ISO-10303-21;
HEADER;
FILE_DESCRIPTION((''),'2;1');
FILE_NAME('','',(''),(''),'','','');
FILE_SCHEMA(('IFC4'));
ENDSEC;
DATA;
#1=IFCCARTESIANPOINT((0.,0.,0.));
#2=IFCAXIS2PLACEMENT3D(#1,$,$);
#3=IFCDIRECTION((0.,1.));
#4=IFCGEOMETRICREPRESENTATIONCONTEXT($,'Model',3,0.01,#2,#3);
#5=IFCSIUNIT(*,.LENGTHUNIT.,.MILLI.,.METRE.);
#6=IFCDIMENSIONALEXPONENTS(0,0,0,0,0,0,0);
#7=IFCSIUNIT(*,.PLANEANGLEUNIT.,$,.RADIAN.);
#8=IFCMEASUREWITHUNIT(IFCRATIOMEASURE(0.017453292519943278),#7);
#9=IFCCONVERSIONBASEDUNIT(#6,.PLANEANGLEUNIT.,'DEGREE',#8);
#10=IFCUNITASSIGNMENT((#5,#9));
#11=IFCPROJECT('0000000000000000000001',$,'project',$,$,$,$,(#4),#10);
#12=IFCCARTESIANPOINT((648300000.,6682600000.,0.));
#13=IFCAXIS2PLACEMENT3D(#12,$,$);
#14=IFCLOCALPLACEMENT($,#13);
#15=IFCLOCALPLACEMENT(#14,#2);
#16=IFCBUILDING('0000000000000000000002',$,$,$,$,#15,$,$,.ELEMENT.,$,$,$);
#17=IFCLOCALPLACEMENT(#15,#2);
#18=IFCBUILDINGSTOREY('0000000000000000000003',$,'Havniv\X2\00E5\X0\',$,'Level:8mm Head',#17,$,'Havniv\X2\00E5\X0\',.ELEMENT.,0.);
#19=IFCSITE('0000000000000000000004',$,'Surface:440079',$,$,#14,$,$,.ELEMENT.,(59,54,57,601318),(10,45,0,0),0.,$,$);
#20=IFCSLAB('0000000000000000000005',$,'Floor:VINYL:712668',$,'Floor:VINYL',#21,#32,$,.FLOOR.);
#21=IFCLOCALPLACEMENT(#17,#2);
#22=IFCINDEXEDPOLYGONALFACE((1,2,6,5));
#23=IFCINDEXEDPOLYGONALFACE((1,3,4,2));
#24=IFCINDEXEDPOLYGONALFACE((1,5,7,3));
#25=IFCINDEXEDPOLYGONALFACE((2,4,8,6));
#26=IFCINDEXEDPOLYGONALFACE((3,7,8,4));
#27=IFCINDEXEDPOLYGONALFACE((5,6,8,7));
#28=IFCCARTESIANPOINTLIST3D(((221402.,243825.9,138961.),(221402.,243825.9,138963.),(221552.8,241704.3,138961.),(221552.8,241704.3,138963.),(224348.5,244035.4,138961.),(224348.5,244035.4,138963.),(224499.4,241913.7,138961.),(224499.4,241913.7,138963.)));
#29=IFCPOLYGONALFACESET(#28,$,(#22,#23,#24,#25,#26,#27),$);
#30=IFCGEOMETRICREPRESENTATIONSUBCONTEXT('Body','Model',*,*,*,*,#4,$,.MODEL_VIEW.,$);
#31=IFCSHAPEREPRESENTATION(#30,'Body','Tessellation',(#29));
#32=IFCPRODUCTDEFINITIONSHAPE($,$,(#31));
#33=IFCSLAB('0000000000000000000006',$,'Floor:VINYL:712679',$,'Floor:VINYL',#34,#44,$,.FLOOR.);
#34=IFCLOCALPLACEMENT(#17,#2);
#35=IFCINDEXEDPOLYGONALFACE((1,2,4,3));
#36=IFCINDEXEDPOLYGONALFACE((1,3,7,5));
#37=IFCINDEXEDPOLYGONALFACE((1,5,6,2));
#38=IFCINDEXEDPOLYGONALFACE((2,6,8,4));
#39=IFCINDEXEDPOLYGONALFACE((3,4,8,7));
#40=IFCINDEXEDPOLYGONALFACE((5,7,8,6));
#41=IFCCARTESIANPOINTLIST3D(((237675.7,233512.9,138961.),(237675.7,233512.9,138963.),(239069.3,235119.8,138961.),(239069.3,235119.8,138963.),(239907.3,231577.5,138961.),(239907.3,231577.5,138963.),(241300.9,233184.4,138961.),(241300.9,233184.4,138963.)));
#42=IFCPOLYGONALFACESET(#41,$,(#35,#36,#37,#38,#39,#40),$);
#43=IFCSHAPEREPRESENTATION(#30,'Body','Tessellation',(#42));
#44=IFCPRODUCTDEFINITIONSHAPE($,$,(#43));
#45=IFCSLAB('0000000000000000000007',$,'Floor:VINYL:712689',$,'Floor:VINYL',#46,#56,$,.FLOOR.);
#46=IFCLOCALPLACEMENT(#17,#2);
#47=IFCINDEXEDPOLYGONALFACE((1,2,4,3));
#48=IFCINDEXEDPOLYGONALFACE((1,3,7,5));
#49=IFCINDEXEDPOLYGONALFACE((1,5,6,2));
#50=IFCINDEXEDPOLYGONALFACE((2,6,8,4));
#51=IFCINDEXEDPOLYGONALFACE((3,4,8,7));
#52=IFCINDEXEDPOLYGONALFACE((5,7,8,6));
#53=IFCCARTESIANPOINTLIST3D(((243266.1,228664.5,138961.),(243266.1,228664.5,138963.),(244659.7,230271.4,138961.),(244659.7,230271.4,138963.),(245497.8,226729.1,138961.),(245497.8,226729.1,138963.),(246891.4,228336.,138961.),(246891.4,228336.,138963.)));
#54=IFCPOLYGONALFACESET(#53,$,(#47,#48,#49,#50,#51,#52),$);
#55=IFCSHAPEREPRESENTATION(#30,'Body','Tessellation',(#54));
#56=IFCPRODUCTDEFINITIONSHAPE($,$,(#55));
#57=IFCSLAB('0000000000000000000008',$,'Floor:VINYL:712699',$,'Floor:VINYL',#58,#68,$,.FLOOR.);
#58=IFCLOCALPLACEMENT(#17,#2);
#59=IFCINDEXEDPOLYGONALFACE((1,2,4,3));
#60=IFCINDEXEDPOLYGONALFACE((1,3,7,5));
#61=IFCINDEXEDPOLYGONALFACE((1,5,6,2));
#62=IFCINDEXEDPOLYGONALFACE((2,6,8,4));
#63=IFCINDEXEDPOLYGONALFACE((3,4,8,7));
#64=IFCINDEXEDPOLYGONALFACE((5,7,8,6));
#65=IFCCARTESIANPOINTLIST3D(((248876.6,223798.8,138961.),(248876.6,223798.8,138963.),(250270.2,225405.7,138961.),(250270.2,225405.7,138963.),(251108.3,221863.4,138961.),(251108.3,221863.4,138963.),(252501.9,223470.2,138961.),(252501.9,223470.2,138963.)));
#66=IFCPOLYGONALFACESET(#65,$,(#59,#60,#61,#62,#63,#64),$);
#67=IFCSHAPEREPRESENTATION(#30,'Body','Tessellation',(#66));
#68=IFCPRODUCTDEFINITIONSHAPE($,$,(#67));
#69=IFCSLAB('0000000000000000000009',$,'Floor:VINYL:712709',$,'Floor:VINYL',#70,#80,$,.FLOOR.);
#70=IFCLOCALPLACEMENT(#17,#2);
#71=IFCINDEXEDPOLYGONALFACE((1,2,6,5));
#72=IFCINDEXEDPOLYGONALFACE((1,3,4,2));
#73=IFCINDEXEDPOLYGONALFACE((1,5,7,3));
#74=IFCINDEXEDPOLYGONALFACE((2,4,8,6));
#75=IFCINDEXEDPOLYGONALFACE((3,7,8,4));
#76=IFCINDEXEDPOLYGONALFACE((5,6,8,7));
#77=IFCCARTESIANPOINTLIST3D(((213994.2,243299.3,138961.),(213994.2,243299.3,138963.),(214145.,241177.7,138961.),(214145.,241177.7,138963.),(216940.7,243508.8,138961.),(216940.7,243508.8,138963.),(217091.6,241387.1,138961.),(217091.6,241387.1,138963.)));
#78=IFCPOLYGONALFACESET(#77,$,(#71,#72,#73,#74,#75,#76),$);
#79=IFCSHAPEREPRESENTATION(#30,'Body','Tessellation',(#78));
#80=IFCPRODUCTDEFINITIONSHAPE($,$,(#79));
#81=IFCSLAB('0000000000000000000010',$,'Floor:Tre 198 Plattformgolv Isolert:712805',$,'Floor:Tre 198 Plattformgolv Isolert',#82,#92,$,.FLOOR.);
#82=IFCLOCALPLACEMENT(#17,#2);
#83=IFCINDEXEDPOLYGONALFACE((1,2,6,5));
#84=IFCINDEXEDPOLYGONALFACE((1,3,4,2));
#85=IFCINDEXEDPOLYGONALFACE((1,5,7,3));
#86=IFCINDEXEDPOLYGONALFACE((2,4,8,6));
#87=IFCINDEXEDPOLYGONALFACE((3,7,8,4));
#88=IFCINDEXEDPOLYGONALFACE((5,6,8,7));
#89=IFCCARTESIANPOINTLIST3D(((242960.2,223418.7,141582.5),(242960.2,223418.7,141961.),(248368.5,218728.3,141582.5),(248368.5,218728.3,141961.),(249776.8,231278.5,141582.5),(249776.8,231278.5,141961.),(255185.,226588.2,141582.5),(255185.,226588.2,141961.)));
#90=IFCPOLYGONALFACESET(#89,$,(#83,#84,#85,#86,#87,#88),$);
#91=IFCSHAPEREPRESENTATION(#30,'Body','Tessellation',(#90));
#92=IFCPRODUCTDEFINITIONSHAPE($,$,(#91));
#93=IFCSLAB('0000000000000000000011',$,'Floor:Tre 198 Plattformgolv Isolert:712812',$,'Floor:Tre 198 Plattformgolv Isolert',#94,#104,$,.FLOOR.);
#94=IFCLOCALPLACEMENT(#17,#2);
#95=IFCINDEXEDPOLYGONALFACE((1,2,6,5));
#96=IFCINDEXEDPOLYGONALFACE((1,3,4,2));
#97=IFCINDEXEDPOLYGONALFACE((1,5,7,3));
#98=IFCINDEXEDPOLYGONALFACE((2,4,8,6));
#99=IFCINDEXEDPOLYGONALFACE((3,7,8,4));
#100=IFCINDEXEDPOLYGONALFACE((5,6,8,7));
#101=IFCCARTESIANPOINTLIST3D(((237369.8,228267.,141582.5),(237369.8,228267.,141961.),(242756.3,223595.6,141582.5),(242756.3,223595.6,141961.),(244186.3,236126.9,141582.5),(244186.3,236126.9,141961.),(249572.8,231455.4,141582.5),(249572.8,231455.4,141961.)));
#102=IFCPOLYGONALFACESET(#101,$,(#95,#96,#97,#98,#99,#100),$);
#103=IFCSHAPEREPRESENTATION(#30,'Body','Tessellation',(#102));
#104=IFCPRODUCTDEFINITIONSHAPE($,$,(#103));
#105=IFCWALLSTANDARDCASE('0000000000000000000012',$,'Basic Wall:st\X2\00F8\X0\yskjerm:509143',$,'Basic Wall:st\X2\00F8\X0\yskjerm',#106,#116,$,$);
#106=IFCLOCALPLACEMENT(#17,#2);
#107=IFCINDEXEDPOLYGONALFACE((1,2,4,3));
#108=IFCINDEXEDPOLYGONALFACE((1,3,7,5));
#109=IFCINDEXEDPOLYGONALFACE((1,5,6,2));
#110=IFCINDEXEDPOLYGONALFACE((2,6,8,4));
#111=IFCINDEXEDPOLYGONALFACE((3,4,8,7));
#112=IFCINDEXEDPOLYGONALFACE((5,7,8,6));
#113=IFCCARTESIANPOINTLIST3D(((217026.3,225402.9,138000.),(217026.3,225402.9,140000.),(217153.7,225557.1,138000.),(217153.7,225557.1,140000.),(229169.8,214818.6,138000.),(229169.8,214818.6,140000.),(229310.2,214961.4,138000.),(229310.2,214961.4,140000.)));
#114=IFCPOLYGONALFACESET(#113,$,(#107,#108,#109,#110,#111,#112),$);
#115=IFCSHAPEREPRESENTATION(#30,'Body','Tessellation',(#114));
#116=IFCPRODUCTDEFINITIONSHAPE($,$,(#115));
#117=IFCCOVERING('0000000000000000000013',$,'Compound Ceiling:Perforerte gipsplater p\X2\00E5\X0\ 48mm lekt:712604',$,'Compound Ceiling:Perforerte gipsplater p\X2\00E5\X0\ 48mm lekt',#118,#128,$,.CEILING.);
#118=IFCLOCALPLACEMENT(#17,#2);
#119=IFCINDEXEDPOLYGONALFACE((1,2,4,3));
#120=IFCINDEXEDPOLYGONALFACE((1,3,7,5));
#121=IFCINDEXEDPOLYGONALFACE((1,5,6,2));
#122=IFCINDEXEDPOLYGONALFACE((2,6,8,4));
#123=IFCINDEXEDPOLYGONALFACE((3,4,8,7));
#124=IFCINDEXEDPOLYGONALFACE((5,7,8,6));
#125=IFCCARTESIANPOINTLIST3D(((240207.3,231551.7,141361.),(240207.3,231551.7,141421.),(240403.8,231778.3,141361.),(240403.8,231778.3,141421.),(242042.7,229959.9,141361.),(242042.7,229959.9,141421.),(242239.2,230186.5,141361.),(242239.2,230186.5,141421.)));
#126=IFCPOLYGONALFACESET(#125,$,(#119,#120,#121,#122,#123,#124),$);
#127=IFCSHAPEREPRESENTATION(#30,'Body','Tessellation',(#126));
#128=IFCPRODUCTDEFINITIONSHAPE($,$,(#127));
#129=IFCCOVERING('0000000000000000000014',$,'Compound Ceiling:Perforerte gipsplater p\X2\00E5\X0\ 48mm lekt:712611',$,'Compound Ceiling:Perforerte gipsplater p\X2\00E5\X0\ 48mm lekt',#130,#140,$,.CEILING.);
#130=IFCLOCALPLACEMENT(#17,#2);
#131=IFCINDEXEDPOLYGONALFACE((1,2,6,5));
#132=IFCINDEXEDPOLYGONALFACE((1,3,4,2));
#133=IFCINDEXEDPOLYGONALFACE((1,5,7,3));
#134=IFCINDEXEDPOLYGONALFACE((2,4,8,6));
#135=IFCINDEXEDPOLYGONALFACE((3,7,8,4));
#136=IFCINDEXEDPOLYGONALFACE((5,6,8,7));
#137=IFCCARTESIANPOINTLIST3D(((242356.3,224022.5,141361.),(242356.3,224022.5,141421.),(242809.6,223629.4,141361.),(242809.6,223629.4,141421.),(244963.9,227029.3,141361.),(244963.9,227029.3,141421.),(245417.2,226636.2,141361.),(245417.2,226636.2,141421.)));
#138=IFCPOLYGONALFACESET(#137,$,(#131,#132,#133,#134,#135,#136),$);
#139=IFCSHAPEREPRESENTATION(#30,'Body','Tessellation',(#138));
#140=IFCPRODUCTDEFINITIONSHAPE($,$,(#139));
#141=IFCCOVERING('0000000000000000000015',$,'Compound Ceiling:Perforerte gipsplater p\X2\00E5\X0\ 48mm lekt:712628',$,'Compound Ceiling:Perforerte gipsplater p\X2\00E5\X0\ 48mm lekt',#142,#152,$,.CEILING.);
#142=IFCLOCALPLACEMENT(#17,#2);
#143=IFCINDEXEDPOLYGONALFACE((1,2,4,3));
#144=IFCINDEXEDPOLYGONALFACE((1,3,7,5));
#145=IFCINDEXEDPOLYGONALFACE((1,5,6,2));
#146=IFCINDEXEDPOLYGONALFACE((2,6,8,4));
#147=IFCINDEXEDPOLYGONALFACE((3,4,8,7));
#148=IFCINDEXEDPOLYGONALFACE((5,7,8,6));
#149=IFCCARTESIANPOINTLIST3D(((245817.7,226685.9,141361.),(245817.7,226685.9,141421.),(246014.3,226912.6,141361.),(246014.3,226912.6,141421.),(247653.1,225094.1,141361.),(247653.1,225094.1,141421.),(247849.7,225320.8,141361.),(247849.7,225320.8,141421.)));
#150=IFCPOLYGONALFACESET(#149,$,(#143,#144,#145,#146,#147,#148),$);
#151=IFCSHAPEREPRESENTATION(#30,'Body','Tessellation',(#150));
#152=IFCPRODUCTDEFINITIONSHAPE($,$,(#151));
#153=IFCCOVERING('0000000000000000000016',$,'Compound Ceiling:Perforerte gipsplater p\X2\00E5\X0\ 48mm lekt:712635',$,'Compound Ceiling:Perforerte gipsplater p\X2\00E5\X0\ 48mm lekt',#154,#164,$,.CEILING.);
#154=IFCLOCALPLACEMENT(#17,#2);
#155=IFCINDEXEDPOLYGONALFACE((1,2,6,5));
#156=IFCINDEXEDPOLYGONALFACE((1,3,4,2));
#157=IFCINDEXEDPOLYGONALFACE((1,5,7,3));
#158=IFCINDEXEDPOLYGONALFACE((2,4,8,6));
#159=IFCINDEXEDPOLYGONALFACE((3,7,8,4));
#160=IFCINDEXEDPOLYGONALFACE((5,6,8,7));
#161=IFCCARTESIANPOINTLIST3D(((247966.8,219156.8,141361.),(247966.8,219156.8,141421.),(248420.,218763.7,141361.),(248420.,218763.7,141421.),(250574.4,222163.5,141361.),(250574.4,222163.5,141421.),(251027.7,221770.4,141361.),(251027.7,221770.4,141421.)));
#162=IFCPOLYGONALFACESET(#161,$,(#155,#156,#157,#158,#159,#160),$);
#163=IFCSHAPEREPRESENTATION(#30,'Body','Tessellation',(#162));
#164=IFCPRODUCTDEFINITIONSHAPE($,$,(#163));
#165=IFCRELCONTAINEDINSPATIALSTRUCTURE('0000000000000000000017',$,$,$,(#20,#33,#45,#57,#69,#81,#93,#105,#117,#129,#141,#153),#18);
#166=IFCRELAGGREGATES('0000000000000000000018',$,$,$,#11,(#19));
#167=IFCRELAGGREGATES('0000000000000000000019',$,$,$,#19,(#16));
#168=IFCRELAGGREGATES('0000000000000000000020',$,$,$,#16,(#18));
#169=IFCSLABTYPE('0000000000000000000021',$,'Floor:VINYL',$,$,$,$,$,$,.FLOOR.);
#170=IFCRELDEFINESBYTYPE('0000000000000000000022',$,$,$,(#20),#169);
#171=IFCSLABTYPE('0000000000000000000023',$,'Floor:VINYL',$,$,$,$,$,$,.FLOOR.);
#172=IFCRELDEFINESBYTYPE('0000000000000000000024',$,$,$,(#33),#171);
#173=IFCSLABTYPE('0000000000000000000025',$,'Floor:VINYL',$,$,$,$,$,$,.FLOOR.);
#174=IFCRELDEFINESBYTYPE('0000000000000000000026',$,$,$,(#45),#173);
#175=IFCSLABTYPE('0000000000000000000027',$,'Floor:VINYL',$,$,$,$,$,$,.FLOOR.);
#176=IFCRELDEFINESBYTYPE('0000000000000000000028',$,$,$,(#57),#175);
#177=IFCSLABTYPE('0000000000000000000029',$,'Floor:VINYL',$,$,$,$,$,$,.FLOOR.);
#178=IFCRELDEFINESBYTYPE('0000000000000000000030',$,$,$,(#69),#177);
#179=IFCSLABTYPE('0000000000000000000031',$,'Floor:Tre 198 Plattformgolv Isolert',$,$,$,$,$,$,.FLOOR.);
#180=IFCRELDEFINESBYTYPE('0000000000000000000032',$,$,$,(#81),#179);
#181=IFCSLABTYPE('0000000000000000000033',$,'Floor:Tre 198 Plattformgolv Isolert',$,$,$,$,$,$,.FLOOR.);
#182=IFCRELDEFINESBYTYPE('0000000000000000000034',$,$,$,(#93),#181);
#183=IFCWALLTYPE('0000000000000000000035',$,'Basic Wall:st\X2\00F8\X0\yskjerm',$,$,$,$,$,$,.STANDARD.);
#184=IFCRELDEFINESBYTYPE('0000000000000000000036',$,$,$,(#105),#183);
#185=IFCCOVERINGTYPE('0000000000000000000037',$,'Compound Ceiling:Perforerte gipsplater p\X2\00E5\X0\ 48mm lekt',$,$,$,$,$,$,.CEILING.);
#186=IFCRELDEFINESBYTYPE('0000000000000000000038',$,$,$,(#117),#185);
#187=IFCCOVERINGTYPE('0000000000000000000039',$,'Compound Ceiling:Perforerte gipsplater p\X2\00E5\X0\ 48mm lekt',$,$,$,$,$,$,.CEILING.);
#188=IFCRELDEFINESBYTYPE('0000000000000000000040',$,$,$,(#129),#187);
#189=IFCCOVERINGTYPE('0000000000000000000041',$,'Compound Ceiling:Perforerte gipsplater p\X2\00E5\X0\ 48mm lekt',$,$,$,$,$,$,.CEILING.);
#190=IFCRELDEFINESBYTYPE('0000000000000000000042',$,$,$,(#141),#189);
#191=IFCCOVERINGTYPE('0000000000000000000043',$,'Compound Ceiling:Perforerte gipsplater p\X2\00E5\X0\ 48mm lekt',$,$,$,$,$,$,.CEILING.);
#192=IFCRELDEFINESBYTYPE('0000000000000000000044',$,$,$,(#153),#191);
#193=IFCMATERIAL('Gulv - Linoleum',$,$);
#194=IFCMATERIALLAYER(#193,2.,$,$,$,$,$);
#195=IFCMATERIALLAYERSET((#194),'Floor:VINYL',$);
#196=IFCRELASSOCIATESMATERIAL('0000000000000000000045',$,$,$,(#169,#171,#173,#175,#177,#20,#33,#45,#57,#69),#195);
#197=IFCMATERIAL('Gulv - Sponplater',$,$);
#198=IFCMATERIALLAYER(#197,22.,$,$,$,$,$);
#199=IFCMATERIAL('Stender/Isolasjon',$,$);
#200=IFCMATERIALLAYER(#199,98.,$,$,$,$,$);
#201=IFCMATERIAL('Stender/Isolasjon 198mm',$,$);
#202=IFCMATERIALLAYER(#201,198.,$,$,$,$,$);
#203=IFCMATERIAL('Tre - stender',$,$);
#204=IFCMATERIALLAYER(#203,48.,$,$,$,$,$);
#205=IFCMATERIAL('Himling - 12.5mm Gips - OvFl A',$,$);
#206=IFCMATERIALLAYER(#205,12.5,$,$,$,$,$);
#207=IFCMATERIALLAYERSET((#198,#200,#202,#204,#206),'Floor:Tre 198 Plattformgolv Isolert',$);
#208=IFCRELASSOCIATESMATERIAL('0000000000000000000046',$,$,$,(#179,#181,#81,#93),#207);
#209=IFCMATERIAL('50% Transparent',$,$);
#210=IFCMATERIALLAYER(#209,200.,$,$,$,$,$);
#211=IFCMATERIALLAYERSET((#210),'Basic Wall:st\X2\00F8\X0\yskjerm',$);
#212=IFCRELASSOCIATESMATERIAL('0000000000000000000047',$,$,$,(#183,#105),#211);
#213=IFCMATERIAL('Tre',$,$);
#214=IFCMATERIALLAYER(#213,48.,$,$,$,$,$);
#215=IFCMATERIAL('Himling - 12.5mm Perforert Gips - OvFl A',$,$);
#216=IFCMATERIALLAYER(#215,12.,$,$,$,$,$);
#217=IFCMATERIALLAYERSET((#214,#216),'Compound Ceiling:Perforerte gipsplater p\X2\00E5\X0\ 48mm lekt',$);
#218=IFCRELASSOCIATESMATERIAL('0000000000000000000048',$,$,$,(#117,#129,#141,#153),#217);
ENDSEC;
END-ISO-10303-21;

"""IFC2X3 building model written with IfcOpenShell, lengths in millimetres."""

from ifc_helpers import new_model, entity, si_unit, converted_unit, direction, frame, frame_2d, origin, origin_2d_with_axis, place, context, subcontext, project, spatial, polyline, rectangle, outline, extrude, material, layer, layer_set, layer_usage, type_object, element, save


model = new_model("IFC2X3")

# Units and contexts
model_context = context("Model", 3, precision=0.01, world=origin(), true_north=direction((0.0, 1.0)))
body_context = subcontext(model_context, "Body", "Model", "MODEL_VIEW")
ifc_project = project(units=[si_unit("LENGTHUNIT", "METRE", prefix="MILLI"), converted_unit("PLANEANGLEUNIT", "DEGREE", entity("IfcRatioMeasure", 0.017453292519943278), si_unit("PLANEANGLEUNIT", "RADIAN"), dimensions=[0, 0, 0, 0, 0, 0, 0])], contexts=[model_context])

# Site, building, storey
site_placement = place(None, frame((648300000.0, 6682600000.0, 0.0)))
site = spatial("IfcSite", under=ifc_project, at=site_placement, Name="Surface:440079", CompositionType="ELEMENT", RefLatitude=(59, 54, 57, 601318), RefLongitude=(10, 45, 0, 0), RefElevation=0.0)
building_placement = place(site_placement, origin())
building = spatial("IfcBuilding", under=site, at=building_placement, CompositionType="ELEMENT")
storey_placement = place(building_placement, origin())
storey = spatial("IfcBuildingStorey", under=building, at=storey_placement, Name="Havnivå", ObjectType="Level:8mm Head", LongName="Havnivå", CompositionType="ELEMENT", Elevation=0.0)

# Shared definitions
ifc_material_1 = material(Name="Tre - stender")

# Slabs
ifc_material_2 = material(Name="Gulv - Linoleum")
ifc_layer_1 = layer(ifc_material_2, 2.0)
ifc_layer_set_1 = layer_set([ifc_layer_1], Name="Floor:VINYL")
ifc_layer_usage_1 = layer_usage(ifc_layer_set_1, "AXIS3", "POSITIVE", 0.0)
slab_type_1 = type_object("IfcSlabType", Name="Floor:VINYL", PredefinedType="FLOOR", material=ifc_layer_set_1)
slab_1_placement = place(storey_placement, origin())
element("IfcSlab", 1, at=slab_1_placement, inside=storey, type_object=slab_type_1, material=ifc_layer_usage_1, Name="Floor:VINYL:712668", ObjectType="Floor:VINYL", PredefinedType="FLOOR", context=body_context, shape_type="SweptSolid", body=[
    extrude(rectangle(XDim=2127.0, YDim=2954.0, at=frame_2d((0.0, 0.0), x_axis=(1.0, 0.0))), frame((222950.7, 242869.8, 138963.0), z_axis=(0.0, 0.0, -1.0), x_axis=(0.070908, -0.997483, 0.0)), (0.0, 0.0, 1.0), 2.0),
])
ifc_layer_usage_2 = layer_usage(ifc_layer_set_1, "AXIS3", "POSITIVE", 0.0)
slab_type_2 = type_object("IfcSlabType", Name="Floor:VINYL", PredefinedType="FLOOR", material=ifc_layer_set_1)
slab_2_placement = place(storey_placement, origin())
element("IfcSlab", 2, at=slab_2_placement, inside=storey, type_object=slab_type_2, material=ifc_layer_usage_2, Name="Floor:VINYL:712679", ObjectType="Floor:VINYL", PredefinedType="FLOOR", context=body_context, shape_type="SweptSolid", body=[
    extrude(rectangle(XDim=2127.0, YDim=2954.0, at=origin_2d_with_axis()), frame((239488.3, 233348.6, 138963.0), z_axis=(0.0, 0.0, -1.0), x_axis=(-0.655187, -0.755467, 0.0)), (0.0, 0.0, 1.0), 2.0),
])
ifc_layer_usage_3 = layer_usage(ifc_layer_set_1, "AXIS3", "POSITIVE", 0.0)
slab_type_3 = type_object("IfcSlabType", Name="Floor:VINYL", PredefinedType="FLOOR", material=ifc_layer_set_1)
slab_3_placement = place(storey_placement, origin())
element("IfcSlab", 3, at=slab_3_placement, inside=storey, type_object=slab_type_3, material=ifc_layer_usage_3, Name="Floor:VINYL:712689", ObjectType="Floor:VINYL", PredefinedType="FLOOR", context=body_context, shape_type="SweptSolid", body=[
    extrude(rectangle(XDim=2127.0, YDim=2954.0, at=frame_2d((0.0, 0.0), x_axis=(1.0, 0.0))), frame((245078.8, 228500.2, 138963.0), z_axis=(0.0, 0.0, -1.0), x_axis=(-0.655187, -0.755467, 0.0)), (0.0, 0.0, 1.0), 2.0),
])
ifc_layer_usage_4 = layer_usage(ifc_layer_set_1, "AXIS3", "POSITIVE", 0.0)
slab_type_4 = type_object("IfcSlabType", Name="Floor:VINYL", PredefinedType="FLOOR", material=ifc_layer_set_1)
slab_4_placement = place(storey_placement, origin())
element("IfcSlab", 4, at=slab_4_placement, inside=storey, type_object=slab_type_4, material=ifc_layer_usage_4, Name="Floor:VINYL:712699", ObjectType="Floor:VINYL", PredefinedType="FLOOR", context=body_context, shape_type="SweptSolid", body=[
    extrude(rectangle(XDim=2127.0, YDim=2954.0, at=frame_2d((0.0, 0.0), x_axis=(1.0, 0.0))), frame((250689.2, 223634.5, 138963.0), z_axis=(0.0, 0.0, -1.0), x_axis=(-0.655187, -0.755467, 0.0)), (0.0, 0.0, 1.0), 2.0),
])
ifc_layer_usage_5 = layer_usage(ifc_layer_set_1, "AXIS3", "POSITIVE", 0.0)
slab_type_5 = type_object("IfcSlabType", Name="Floor:VINYL", PredefinedType="FLOOR", material=ifc_layer_set_1)
slab_5_placement = place(storey_placement, origin())
element("IfcSlab", 5, at=slab_5_placement, inside=storey, type_object=slab_type_5, material=ifc_layer_usage_5, Name="Floor:VINYL:712709", ObjectType="Floor:VINYL", PredefinedType="FLOOR", context=body_context, shape_type="SweptSolid", body=[
    extrude(rectangle(XDim=2127.0, YDim=2954.0, at=frame_2d((0.0, 0.0), x_axis=(1.0, 0.0))), frame((215542.9, 242343.2, 138963.0), z_axis=(0.0, 0.0, -1.0), x_axis=(0.070908, -0.997483, 0.0)), (0.0, 0.0, 1.0), 2.0),
])
ifc_material_3 = material(Name="Gulv - Sponplater")
ifc_layer_2 = layer(ifc_material_3, 22.0)
ifc_material_4 = material(Name="Stender/Isolasjon")
ifc_layer_3 = layer(ifc_material_4, 98.0)
ifc_material_5 = material(Name="Stender/Isolasjon 198mm")
ifc_layer_4 = layer(ifc_material_5, 198.0)
ifc_layer_5 = layer(ifc_material_1, 48.0)
ifc_material_6 = material(Name="Himling - 12.5mm Gips - OvFl A")
ifc_layer_6 = layer(ifc_material_6, 12.5)
ifc_layer_set_2 = layer_set([ifc_layer_2, ifc_layer_3, ifc_layer_4, ifc_layer_5, ifc_layer_6], Name="Floor:Tre 198 Plattformgolv Isolert")
ifc_layer_usage_6 = layer_usage(ifc_layer_set_2, "AXIS3", "POSITIVE", 0.0)
slab_type_6 = type_object("IfcSlabType", Name="Floor:Tre 198 Plattformgolv Isolert", PredefinedType="FLOOR", material=ifc_layer_set_2)
slab_6_placement = place(storey_placement, origin())
element("IfcSlab", 6, at=slab_6_placement, inside=storey, type_object=slab_type_6, material=ifc_layer_usage_6, Name="Floor:Tre 198 Plattformgolv Isolert:712805", ObjectType="Floor:Tre 198 Plattformgolv Isolert", PredefinedType="FLOOR", context=body_context, shape_type="SweptSolid", body=[
    extrude(rectangle(XDim=7158.8, YDim=10404.0, at=frame_2d((0.0, 0.0), x_axis=(1.0, 0.0))), frame((249072.6, 225003.4, 141961.0), z_axis=(0.0, 0.0, -1.0), x_axis=(0.755467, -0.655187, 0.0)), (0.0, 0.0, 1.0), 378.5),
])
ifc_layer_usage_7 = layer_usage(ifc_layer_set_2, "AXIS3", "POSITIVE", 0.0)
slab_type_7 = type_object("IfcSlabType", Name="Floor:Tre 198 Plattformgolv Isolert", PredefinedType="FLOOR", material=ifc_layer_set_2)
slab_7_placement = place(storey_placement, origin())
element("IfcSlab", 7, at=slab_7_placement, inside=storey, type_object=slab_type_7, material=ifc_layer_usage_7, Name="Floor:Tre 198 Plattformgolv Isolert:712812", ObjectType="Floor:Tre 198 Plattformgolv Isolert", PredefinedType="FLOOR", context=body_context, shape_type="SweptSolid", body=[
    extrude(rectangle(XDim=7130.0, YDim=10404.0, at=origin_2d_with_axis()), frame((243471.3, 229861.2, 141961.0), z_axis=(0.0, 0.0, -1.0), x_axis=(0.755467, -0.655187, 0.0)), (0.0, 0.0, 1.0), 378.5),
])

# Wall
ifc_material_7 = material(Name="50% Transparent")
ifc_layer_7 = layer(ifc_material_7, 200.0)
ifc_layer_set_3 = layer_set([ifc_layer_7], Name="Basic Wall:støyskjerm")
ifc_layer_usage_8 = layer_usage(ifc_layer_set_3, "AXIS2", "NEGATIVE", 100.0)
wall_type = type_object("IfcWallType", Name="Basic Wall:støyskjerm", PredefinedType="STANDARD", material=ifc_layer_set_3)
wall_placement = place(storey_placement, frame((217088.0, 225481.7, 138000.0), z_axis=(0.0, 0.0, 1.0), x_axis=(0.753844, -0.657054, 0.0)))
element("IfcWallStandardCase", 8, at=wall_placement, inside=storey, type_object=wall_type, material=ifc_layer_usage_8, Name="Basic Wall:støyskjerm:509143", ObjectType="Basic Wall:støyskjerm", context=body_context, shape_type="SweptSolid", body=[
    extrude(outline(polyline([(16114.0, -100.0), (16126.0, 100.0), (0.0, 100.0), (5.2, -100.0), (16114.0, -100.0)])), origin(), (0.0, 0.0, 1.0), 2000.0),
])

# Coverings
ifc_material_8 = material(Name="Tre")
ifc_layer_8 = layer(ifc_material_8, 48.0)
ifc_material_9 = material(Name="Himling - 12.5mm Perforert Gips - OvFl A")
ifc_layer_9 = layer(ifc_material_9, 12.0)
ifc_layer_set_4 = layer_set([ifc_layer_8, ifc_layer_9], Name="Compound Ceiling:Perforerte gipsplater på 48mm lekt")
ifc_layer_usage_9 = layer_usage(ifc_layer_set_4, "AXIS3", "POSITIVE", 0.0)
covering_type_1 = type_object("IfcCoveringType", Name="Compound Ceiling:Perforerte gipsplater på 48mm lekt", PredefinedType="CEILING")
covering_1_placement = place(storey_placement, origin())
element("IfcCovering", 9, at=covering_1_placement, inside=storey, type_object=covering_type_1, material=ifc_layer_usage_9, Name="Compound Ceiling:Perforerte gipsplater på 48mm lekt:712604", ObjectType="Compound Ceiling:Perforerte gipsplater på 48mm lekt", PredefinedType="CEILING", context=body_context, shape_type="SweptSolid", body=[
    extrude(rectangle(XDim=300.0, YDim=2429.5, at=frame_2d((0.0, 0.0), x_axis=(1.0, 0.0))), frame((241223.2, 230869.1, 141361.0), z_axis=(0.0, 0.0, 1.0), x_axis=(0.655187, 0.755467, 0.0)), (0.0, 0.0, 1.0), 60.0),
])
ifc_layer_usage_10 = layer_usage(ifc_layer_set_4, "AXIS3", "POSITIVE", 0.0)
covering_type_2 = type_object("IfcCoveringType", Name="Compound Ceiling:Perforerte gipsplater på 48mm lekt", PredefinedType="CEILING")
covering_2_placement = place(storey_placement, origin())
element("IfcCovering", 10, at=covering_2_placement, inside=storey, type_object=covering_type_2, material=ifc_layer_usage_10, Name="Compound Ceiling:Perforerte gipsplater på 48mm lekt:712611", ObjectType="Compound Ceiling:Perforerte gipsplater på 48mm lekt", PredefinedType="CEILING", context=body_context, shape_type="SweptSolid", body=[
    extrude(rectangle(XDim=3980.0, YDim=600.0, at=frame_2d((0.0, 0.0), x_axis=(1.0, 0.0))), frame((243886.7, 225329.4, 141361.0), z_axis=(0.0, 0.0, 1.0), x_axis=(-0.655187, -0.755467, 0.0)), (0.0, 0.0, 1.0), 60.0),
])
ifc_layer_usage_11 = layer_usage(ifc_layer_set_4, "AXIS3", "POSITIVE", 0.0)
covering_type_3 = type_object("IfcCoveringType", Name="Compound Ceiling:Perforerte gipsplater på 48mm lekt", PredefinedType="CEILING")
covering_3_placement = place(storey_placement, origin())
element("IfcCovering", 11, at=covering_3_placement, inside=storey, type_object=covering_type_3, material=ifc_layer_usage_11, Name="Compound Ceiling:Perforerte gipsplater på 48mm lekt:712628", ObjectType="Compound Ceiling:Perforerte gipsplater på 48mm lekt", PredefinedType="CEILING", context=body_context, shape_type="SweptSolid", body=[
    extrude(rectangle(XDim=300.0, YDim=2429.5, at=frame_2d((0.0, 0.0), x_axis=(1.0, 0.0))), frame((246833.7, 226003.3, 141361.0), z_axis=(0.0, 0.0, 1.0), x_axis=(0.655187, 0.755467, 0.0)), (0.0, 0.0, 1.0), 60.0),
])
ifc_layer_usage_12 = layer_usage(ifc_layer_set_4, "AXIS3", "POSITIVE", 0.0)
covering_type_4 = type_object("IfcCoveringType", Name="Compound Ceiling:Perforerte gipsplater på 48mm lekt", PredefinedType="CEILING")
covering_4_placement = place(storey_placement, origin())
element("IfcCovering", 12, at=covering_4_placement, inside=storey, type_object=covering_type_4, material=ifc_layer_usage_12, Name="Compound Ceiling:Perforerte gipsplater på 48mm lekt:712635", ObjectType="Compound Ceiling:Perforerte gipsplater på 48mm lekt", PredefinedType="CEILING", context=body_context, shape_type="SweptSolid", body=[
    extrude(rectangle(XDim=3980.0, YDim=600.0, at=frame_2d((0.0, 0.0), x_axis=(1.0, 0.0))), frame((249497.2, 220463.6, 141361.0), z_axis=(0.0, 0.0, 1.0), x_axis=(-0.655187, -0.755467, 0.0)), (0.0, 0.0, 1.0), 60.0),
])

save(model, "model.ifc")
